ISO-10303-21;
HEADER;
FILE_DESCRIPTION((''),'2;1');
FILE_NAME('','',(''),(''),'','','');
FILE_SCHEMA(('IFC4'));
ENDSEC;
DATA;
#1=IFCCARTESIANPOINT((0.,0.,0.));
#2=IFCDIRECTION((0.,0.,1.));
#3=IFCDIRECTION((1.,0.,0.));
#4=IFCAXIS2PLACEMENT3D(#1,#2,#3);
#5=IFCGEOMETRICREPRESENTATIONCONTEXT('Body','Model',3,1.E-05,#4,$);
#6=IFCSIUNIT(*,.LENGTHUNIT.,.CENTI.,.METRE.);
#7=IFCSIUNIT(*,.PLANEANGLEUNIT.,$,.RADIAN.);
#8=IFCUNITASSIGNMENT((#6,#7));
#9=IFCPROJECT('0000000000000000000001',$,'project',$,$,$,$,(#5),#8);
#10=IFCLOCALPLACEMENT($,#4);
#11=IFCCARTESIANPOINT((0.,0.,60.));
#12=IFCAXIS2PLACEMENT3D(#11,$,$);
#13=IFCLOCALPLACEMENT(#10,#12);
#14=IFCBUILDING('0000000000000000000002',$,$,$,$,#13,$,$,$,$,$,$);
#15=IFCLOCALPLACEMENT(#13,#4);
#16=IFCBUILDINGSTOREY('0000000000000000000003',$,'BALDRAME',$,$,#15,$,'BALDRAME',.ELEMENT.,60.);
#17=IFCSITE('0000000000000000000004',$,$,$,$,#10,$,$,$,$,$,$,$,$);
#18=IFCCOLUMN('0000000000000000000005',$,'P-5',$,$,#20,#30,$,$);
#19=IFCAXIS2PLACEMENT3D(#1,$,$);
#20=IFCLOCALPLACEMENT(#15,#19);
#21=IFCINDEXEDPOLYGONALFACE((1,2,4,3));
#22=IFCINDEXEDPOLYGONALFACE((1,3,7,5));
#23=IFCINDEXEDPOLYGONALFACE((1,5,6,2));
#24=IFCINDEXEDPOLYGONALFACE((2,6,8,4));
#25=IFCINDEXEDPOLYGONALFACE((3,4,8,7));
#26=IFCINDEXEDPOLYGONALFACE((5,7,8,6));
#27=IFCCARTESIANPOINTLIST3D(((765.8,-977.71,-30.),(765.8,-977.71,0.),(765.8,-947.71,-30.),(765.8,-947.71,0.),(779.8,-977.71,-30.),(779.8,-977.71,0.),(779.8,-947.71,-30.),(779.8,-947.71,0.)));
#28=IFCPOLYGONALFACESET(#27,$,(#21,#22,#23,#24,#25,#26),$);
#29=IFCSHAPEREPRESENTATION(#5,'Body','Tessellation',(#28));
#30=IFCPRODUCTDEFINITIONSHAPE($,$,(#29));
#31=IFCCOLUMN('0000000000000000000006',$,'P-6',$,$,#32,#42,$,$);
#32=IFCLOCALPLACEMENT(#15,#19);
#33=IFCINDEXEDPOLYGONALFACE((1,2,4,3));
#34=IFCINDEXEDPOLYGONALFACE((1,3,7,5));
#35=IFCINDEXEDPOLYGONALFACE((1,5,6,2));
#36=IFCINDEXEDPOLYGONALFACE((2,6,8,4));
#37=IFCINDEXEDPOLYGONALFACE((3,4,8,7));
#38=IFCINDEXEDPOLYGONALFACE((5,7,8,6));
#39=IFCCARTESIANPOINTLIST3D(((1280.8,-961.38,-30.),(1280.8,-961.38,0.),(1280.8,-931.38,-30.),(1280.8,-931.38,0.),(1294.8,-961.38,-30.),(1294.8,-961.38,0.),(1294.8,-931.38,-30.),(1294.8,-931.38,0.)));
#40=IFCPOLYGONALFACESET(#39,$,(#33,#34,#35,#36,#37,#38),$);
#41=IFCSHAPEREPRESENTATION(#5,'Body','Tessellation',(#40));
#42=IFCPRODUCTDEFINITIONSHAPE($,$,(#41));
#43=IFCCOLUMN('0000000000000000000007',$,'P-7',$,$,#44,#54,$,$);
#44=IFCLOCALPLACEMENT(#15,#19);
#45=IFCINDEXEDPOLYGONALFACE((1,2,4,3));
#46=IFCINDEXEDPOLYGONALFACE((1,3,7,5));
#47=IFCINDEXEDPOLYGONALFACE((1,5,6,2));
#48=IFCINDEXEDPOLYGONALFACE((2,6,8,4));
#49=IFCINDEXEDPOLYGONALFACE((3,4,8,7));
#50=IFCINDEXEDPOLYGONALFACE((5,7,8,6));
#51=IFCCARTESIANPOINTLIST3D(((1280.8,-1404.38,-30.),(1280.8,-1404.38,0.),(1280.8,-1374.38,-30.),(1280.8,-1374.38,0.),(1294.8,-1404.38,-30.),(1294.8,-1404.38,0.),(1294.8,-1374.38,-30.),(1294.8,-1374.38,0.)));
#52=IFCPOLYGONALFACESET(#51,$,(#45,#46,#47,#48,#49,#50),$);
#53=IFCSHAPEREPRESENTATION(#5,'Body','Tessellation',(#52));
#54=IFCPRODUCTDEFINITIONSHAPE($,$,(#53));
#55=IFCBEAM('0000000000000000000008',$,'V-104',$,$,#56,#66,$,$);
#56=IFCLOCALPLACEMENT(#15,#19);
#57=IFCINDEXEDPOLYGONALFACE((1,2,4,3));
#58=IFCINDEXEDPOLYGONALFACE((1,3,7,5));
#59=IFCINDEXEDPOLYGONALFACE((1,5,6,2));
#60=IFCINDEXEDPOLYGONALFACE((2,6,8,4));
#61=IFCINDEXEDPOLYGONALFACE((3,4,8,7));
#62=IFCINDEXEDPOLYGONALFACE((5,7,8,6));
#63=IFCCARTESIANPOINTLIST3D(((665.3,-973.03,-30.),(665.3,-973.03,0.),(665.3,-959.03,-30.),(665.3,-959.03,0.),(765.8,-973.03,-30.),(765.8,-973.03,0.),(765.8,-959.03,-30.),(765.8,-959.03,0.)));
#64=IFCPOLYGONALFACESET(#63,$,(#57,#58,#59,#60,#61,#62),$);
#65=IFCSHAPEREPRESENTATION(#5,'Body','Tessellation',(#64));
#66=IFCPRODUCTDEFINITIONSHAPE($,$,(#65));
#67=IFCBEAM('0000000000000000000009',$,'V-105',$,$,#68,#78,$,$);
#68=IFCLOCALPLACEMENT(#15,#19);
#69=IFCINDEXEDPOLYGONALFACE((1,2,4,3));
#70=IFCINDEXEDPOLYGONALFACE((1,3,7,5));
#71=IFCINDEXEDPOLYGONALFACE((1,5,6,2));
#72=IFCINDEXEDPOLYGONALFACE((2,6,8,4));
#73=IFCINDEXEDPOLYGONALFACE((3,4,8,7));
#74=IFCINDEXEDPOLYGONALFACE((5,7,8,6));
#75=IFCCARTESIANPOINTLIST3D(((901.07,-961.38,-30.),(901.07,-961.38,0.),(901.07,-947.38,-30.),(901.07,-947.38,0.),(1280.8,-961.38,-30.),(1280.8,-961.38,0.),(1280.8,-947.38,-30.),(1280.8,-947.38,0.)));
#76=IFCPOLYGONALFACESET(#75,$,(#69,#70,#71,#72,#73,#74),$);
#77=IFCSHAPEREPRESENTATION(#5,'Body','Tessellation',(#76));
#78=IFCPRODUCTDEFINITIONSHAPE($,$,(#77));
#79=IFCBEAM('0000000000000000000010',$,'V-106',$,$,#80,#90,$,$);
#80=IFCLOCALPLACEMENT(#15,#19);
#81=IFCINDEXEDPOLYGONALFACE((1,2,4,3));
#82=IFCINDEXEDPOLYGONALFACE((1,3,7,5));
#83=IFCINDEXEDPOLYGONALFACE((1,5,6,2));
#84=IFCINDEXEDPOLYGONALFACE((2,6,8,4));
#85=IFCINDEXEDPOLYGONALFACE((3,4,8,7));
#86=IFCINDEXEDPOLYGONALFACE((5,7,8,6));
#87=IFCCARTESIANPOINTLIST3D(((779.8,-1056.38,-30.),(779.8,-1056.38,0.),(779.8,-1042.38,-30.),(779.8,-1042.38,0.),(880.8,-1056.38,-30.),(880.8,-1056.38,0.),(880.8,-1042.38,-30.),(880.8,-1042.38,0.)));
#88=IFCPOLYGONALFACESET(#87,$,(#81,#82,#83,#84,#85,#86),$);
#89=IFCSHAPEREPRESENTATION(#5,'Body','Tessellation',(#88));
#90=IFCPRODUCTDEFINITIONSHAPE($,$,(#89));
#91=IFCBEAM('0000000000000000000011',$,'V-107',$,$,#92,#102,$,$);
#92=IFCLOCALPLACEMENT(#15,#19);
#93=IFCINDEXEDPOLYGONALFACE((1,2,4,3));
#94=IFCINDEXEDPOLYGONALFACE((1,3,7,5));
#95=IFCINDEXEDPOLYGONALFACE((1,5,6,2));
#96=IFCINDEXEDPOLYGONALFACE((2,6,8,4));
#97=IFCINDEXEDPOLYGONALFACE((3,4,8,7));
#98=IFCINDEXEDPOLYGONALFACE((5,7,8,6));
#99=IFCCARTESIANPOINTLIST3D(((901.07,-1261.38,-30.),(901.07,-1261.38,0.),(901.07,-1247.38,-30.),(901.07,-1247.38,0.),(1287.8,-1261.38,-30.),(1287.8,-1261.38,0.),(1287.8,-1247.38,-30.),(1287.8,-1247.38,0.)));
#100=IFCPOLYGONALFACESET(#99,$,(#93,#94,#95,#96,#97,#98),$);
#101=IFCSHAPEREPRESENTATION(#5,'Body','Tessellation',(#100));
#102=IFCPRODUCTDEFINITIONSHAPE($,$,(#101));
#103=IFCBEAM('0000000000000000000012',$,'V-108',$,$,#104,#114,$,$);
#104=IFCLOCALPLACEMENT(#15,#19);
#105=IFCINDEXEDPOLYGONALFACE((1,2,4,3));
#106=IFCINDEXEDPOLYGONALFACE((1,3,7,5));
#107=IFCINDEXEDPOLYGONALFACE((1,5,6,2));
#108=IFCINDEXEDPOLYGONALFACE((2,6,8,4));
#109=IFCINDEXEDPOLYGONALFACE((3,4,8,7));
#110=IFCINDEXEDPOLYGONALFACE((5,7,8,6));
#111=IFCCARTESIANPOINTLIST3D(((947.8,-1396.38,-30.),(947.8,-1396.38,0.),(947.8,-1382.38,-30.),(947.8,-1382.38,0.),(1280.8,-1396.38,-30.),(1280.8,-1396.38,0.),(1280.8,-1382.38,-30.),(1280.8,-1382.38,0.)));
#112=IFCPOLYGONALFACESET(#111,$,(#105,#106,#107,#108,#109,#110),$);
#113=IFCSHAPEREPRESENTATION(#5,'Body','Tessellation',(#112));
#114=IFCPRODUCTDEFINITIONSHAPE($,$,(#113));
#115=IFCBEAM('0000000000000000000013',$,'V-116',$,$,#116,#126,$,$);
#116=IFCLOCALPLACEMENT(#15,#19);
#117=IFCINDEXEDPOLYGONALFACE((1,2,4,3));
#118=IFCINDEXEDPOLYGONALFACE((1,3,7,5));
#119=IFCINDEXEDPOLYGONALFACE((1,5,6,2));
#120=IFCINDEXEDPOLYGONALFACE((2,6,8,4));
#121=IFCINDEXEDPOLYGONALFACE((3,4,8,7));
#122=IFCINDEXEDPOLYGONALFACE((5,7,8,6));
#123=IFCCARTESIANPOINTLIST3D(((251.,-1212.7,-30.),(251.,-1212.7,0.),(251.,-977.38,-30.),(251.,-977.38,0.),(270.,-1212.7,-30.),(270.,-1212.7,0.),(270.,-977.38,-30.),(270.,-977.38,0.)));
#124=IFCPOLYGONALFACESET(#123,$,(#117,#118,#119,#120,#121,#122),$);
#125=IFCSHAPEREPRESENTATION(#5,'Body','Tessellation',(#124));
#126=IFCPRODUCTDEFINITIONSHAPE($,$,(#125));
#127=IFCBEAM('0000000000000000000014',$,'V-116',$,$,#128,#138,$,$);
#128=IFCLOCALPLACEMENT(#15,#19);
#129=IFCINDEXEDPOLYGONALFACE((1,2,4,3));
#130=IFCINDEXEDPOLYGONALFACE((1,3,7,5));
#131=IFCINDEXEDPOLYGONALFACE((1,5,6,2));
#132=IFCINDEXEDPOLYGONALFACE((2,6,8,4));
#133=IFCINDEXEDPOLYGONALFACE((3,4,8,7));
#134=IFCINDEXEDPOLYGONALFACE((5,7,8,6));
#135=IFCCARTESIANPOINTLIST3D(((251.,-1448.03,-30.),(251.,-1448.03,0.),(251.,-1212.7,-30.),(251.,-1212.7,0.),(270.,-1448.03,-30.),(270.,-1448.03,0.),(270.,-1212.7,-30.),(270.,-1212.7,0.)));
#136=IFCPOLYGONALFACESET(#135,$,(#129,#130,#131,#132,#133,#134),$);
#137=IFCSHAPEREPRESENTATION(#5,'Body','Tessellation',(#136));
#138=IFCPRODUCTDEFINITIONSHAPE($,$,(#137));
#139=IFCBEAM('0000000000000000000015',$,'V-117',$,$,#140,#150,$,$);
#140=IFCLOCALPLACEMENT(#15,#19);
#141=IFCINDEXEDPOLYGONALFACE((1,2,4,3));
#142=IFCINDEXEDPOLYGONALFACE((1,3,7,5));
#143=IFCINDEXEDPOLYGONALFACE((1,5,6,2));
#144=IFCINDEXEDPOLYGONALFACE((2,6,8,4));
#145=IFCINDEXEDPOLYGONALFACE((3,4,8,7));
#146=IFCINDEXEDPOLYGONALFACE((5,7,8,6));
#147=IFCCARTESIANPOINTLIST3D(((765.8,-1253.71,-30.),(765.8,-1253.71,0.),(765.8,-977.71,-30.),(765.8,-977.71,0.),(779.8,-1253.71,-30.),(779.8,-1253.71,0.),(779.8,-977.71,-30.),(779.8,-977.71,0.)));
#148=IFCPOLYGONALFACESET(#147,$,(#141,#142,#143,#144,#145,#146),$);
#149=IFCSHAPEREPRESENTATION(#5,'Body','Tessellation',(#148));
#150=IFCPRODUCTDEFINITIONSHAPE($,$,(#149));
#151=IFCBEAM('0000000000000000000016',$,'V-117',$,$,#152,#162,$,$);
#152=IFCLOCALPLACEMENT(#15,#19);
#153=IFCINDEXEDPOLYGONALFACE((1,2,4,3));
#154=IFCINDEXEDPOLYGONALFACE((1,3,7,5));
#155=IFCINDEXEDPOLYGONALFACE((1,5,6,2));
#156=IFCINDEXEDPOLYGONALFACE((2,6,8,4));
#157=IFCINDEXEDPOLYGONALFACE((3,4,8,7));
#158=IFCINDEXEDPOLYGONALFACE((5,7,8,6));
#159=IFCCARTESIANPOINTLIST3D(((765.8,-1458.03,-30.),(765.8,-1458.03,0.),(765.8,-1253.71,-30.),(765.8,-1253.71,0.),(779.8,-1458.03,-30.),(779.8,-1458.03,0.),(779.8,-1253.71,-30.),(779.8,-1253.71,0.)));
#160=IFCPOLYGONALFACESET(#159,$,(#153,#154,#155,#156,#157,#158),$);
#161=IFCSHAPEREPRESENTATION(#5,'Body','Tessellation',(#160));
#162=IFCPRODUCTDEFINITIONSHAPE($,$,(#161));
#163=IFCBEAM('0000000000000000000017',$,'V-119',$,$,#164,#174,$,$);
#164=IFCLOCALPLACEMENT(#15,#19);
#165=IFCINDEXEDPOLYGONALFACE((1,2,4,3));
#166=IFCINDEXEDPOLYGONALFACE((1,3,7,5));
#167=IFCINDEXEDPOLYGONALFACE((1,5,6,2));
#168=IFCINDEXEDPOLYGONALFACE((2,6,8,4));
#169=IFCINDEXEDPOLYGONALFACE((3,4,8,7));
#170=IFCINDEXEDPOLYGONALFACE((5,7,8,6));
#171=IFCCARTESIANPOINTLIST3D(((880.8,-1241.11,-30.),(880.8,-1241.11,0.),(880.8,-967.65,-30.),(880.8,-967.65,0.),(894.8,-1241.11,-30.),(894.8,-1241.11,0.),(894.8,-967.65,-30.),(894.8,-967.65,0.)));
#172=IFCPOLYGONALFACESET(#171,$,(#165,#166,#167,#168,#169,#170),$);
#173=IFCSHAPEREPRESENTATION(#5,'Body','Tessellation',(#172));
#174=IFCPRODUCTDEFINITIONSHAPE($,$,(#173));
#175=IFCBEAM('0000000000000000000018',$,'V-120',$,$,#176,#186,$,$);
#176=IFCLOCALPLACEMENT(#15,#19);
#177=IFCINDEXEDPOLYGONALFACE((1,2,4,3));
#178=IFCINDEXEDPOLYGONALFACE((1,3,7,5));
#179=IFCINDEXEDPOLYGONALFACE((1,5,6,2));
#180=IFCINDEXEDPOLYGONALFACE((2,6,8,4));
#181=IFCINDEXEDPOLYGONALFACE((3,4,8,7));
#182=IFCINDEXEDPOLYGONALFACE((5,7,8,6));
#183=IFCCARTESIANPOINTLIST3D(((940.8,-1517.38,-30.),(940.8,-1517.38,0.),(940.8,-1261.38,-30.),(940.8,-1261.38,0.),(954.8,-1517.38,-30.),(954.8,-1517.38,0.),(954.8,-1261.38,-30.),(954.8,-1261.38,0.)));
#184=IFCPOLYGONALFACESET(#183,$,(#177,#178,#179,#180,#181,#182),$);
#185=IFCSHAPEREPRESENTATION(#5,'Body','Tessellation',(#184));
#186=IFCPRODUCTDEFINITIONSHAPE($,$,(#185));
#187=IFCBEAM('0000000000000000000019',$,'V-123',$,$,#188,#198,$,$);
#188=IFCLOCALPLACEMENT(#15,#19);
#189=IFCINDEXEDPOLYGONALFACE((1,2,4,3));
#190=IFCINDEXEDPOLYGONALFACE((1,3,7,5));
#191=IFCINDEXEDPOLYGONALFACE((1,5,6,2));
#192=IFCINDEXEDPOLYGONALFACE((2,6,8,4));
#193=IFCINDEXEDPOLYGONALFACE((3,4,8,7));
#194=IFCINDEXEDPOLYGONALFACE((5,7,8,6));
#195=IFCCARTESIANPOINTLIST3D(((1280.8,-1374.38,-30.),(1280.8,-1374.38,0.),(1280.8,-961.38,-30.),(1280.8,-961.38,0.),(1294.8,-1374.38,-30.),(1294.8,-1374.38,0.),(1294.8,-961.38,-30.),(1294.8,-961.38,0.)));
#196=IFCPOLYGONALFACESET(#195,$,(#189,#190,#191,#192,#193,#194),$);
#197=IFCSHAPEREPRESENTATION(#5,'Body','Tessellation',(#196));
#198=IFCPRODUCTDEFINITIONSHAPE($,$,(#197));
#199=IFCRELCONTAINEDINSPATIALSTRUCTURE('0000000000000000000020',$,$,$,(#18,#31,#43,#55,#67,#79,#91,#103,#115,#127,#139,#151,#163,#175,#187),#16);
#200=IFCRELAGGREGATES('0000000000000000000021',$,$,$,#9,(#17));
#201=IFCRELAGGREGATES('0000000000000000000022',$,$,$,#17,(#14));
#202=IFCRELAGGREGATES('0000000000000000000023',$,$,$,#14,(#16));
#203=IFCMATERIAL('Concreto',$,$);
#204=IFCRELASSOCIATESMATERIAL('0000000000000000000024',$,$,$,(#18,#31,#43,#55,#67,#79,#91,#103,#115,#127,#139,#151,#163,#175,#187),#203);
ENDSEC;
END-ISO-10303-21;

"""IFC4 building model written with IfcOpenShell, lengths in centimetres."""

from ifc_helpers import new_model, si_unit, frame, origin_with_axes, origin_2d_with_axis, place, context, project, spatial, rectangle, extrude, material, element, save


model = new_model("IFC4")

# Units and contexts
model_context = context("Model", 3, precision=1e-05, world=origin_with_axes(), identifier="Body")
ifc_project = project(units=[si_unit("LENGTHUNIT", "METRE", prefix="CENTI"), si_unit("PLANEANGLEUNIT", "RADIAN")], contexts=[model_context])

# Site, building, storey
site_placement = place(None, origin_with_axes())
site = spatial("IfcSite", under=ifc_project, at=site_placement)
building_placement = place(site_placement, frame((0.0, 0.0, 60.0)))
building = spatial("IfcBuilding", under=site, at=building_placement)
storey_placement = place(building_placement, origin_with_axes())
storey = spatial("IfcBuildingStorey", under=building, at=storey_placement, Name="BALDRAME", LongName="BALDRAME", CompositionType="ELEMENT", Elevation=60.0)

# Shared definitions
ifc_material = material(Name="Concreto")

# Columns
for number, where, z_axis, x_axis, name in (
    (1, (772.8, -962.71, 0.0), (0.0, 0.0, 1.0), (1.0, 0.0, 0.0), "P-5"),
    (2, (1287.8, -946.38, 0.0), (0.0, 0.0, 1.0), (1.0, 0.0, 0.0), "P-6"),
    (3, (1287.8, -1389.38, 0.0), (0.0, 0.0, 1.0), (1.0, 0.0, 0.0), "P-7"),
):
    element("IfcColumn", number, at=place(storey_placement, frame(where, z_axis=z_axis, x_axis=x_axis)), inside=storey, material=ifc_material, Name=name, context=model_context, shape_type="SolidModel", body=[
        extrude(rectangle(XDim=14.0, YDim=30.0, at=origin_2d_with_axis()), frame((0.0, 0.0, -30.0), z_axis=(0.0, 0.0, 1.0), x_axis=(1.0, 0.0, 0.0)), (0.0, 0.0, 1.0), 30.0),
    ])

# Beams
beam_1_placement = place(storey_placement, frame((715.55, -966.03, 0.0), z_axis=(0.0, 0.0, 1.0), x_axis=(1.0, 0.0, 0.0)))
element("IfcBeam", 4, at=beam_1_placement, inside=storey, material=ifc_material, Name="V-104", context=model_context, shape_type="SolidModel", body=[
    extrude(rectangle(XDim=14.0, YDim=30.0, at=origin_2d_with_axis()), frame((-50.25, 0.0, -15.0), z_axis=(1.0, 0.0, 0.0), x_axis=(0.0, -1.0, 0.0)), (0.0, 0.0, 1.0), 100.5),
])
beam_2_placement = place(storey_placement, frame((1090.93, -954.38, 0.0), z_axis=(0.0, 0.0, 1.0), x_axis=(1.0, 0.0, 0.0)))
element("IfcBeam", 5, at=beam_2_placement, inside=storey, material=ifc_material, Name="V-105", context=model_context, shape_type="SolidModel", body=[
    extrude(rectangle(XDim=14.0, YDim=30.0, at=origin_2d_with_axis()), frame((-189.87, 0.0, -15.0), z_axis=(1.0, 0.0, 0.0), x_axis=(0.0, -1.0, 0.0)), (0.0, 0.0, 1.0), 379.73),
])
beam_3_placement = place(storey_placement, frame((830.3, -1049.38, 0.0), z_axis=(0.0, 0.0, 1.0), x_axis=(1.0, 0.0, 0.0)))
element("IfcBeam", 6, at=beam_3_placement, inside=storey, material=ifc_material, Name="V-106", context=model_context, shape_type="SolidModel", body=[
    extrude(rectangle(XDim=14.0, YDim=30.0, at=origin_2d_with_axis()), frame((-50.5, 0.0, -15.0), z_axis=(1.0, 0.0, 0.0), x_axis=(0.0, -1.0, 0.0)), (0.0, 0.0, 1.0), 101.0),
])
beam_4_placement = place(storey_placement, frame((1094.43, -1254.38, 0.0), z_axis=(0.0, 0.0, 1.0), x_axis=(1.0, 0.0, 0.0)))
element("IfcBeam", 7, at=beam_4_placement, inside=storey, material=ifc_material, Name="V-107", context=model_context, shape_type="SolidModel", body=[
    extrude(rectangle(XDim=14.0, YDim=30.0, at=origin_2d_with_axis()), frame((-193.37, 0.0, -15.0), z_axis=(1.0, 0.0, 0.0), x_axis=(0.0, -1.0, 0.0)), (0.0, 0.0, 1.0), 386.73),
])
beam_5_placement = place(storey_placement, frame((1114.3, -1389.38, 0.0), z_axis=(0.0, 0.0, 1.0), x_axis=(1.0, 0.0, 0.0)))
element("IfcBeam", 8, at=beam_5_placement, inside=storey, material=ifc_material, Name="V-108", context=model_context, shape_type="SolidModel", body=[
    extrude(rectangle(XDim=14.0, YDim=30.0, at=origin_2d_with_axis()), frame((-166.5, 0.0, -15.0), z_axis=(1.0, 0.0, 0.0), x_axis=(0.0, -1.0, 0.0)), (0.0, 0.0, 1.0), 333.0),
])
beam_6_placement = place(storey_placement, frame((260.5, -1095.04, 0.0), z_axis=(0.0, 0.0, 1.0), x_axis=(1.0, 0.0, 0.0)))
element("IfcBeam", 9, at=beam_6_placement, inside=storey, material=ifc_material, Name="V-116", context=model_context, shape_type="SolidModel", body=[
    extrude(rectangle(XDim=19.0, YDim=30.0, at=origin_2d_with_axis()), frame((0.0, -117.66, -15.0), z_axis=(0.0, 1.0, 0.0), x_axis=(1.0, 0.0, 0.0)), (0.0, 0.0, 1.0), 235.32),
])
beam_7_placement = place(storey_placement, frame((260.5, -1330.37, 0.0), z_axis=(0.0, 0.0, 1.0), x_axis=(1.0, 0.0, 0.0)))
element("IfcBeam", 10, at=beam_7_placement, inside=storey, material=ifc_material, Name="V-116", context=model_context, shape_type="SolidModel", body=[
    extrude(rectangle(XDim=19.0, YDim=30.0, at=origin_2d_with_axis()), frame((0.0, -117.67, -15.0), z_axis=(0.0, 1.0, 0.0), x_axis=(1.0, 0.0, 0.0)), (0.0, 0.0, 1.0), 235.33),
])
beam_8_placement = place(storey_placement, frame((772.8, -1115.71, 0.0), z_axis=(0.0, 0.0, 1.0), x_axis=(1.0, 0.0, 0.0)))
element("IfcBeam", 11, at=beam_8_placement, inside=storey, material=ifc_material, Name="V-117", context=model_context, shape_type="SolidModel", body=[
    extrude(rectangle(XDim=14.0, YDim=30.0, at=origin_2d_with_axis()), frame((0.0, -138.0, -15.0), z_axis=(0.0, 1.0, 0.0), x_axis=(1.0, 0.0, 0.0)), (0.0, 0.0, 1.0), 276.0),
])
beam_9_placement = place(storey_placement, frame((772.8, -1355.87, 0.0), z_axis=(0.0, 0.0, 1.0), x_axis=(1.0, 0.0, 0.0)))
element("IfcBeam", 12, at=beam_9_placement, inside=storey, material=ifc_material, Name="V-117", context=model_context, shape_type="SolidModel", body=[
    extrude(rectangle(XDim=14.0, YDim=30.0, at=origin_2d_with_axis()), frame((0.0, -102.16, -15.0), z_axis=(0.0, 1.0, 0.0), x_axis=(1.0, 0.0, 0.0)), (0.0, 0.0, 1.0), 204.32),
])
beam_10_placement = place(storey_placement, frame((887.8, -1104.38, 0.0), z_axis=(0.0, 0.0, 1.0), x_axis=(1.0, 0.0, 0.0)))
element("IfcBeam", 13, at=beam_10_placement, inside=storey, material=ifc_material, Name="V-119", context=model_context, shape_type="SolidModel", body=[
    extrude(rectangle(XDim=14.0, YDim=30.0, at=origin_2d_with_axis()), frame((0.0, -136.73, -15.0), z_axis=(0.0, 1.0, 0.0), x_axis=(1.0, 0.0, 0.0)), (0.0, 0.0, 1.0), 273.47),
])
beam_11_placement = place(storey_placement, frame((947.8, -1389.38, 0.0), z_axis=(0.0, 0.0, 1.0), x_axis=(1.0, 0.0, 0.0)))
element("IfcBeam", 14, at=beam_11_placement, inside=storey, material=ifc_material, Name="V-120", context=model_context, shape_type="SolidModel", body=[
    extrude(rectangle(XDim=14.0, YDim=30.0, at=origin_2d_with_axis()), frame((0.0, -128.0, -15.0), z_axis=(0.0, 1.0, 0.0), x_axis=(1.0, 0.0, 0.0)), (0.0, 0.0, 1.0), 256.0),
])
beam_12_placement = place(storey_placement, frame((1287.8, -1167.88, 0.0), z_axis=(0.0, 0.0, 1.0), x_axis=(1.0, 0.0, 0.0)))
element("IfcBeam", 15, at=beam_12_placement, inside=storey, material=ifc_material, Name="V-123", context=model_context, shape_type="SolidModel", body=[
    extrude(rectangle(XDim=14.0, YDim=30.0, at=origin_2d_with_axis()), frame((0.0, -206.5, -15.0), z_axis=(0.0, 1.0, 0.0), x_axis=(1.0, 0.0, 0.0)), (0.0, 0.0, 1.0), 413.0),
])

save(model, "model.ifc")
